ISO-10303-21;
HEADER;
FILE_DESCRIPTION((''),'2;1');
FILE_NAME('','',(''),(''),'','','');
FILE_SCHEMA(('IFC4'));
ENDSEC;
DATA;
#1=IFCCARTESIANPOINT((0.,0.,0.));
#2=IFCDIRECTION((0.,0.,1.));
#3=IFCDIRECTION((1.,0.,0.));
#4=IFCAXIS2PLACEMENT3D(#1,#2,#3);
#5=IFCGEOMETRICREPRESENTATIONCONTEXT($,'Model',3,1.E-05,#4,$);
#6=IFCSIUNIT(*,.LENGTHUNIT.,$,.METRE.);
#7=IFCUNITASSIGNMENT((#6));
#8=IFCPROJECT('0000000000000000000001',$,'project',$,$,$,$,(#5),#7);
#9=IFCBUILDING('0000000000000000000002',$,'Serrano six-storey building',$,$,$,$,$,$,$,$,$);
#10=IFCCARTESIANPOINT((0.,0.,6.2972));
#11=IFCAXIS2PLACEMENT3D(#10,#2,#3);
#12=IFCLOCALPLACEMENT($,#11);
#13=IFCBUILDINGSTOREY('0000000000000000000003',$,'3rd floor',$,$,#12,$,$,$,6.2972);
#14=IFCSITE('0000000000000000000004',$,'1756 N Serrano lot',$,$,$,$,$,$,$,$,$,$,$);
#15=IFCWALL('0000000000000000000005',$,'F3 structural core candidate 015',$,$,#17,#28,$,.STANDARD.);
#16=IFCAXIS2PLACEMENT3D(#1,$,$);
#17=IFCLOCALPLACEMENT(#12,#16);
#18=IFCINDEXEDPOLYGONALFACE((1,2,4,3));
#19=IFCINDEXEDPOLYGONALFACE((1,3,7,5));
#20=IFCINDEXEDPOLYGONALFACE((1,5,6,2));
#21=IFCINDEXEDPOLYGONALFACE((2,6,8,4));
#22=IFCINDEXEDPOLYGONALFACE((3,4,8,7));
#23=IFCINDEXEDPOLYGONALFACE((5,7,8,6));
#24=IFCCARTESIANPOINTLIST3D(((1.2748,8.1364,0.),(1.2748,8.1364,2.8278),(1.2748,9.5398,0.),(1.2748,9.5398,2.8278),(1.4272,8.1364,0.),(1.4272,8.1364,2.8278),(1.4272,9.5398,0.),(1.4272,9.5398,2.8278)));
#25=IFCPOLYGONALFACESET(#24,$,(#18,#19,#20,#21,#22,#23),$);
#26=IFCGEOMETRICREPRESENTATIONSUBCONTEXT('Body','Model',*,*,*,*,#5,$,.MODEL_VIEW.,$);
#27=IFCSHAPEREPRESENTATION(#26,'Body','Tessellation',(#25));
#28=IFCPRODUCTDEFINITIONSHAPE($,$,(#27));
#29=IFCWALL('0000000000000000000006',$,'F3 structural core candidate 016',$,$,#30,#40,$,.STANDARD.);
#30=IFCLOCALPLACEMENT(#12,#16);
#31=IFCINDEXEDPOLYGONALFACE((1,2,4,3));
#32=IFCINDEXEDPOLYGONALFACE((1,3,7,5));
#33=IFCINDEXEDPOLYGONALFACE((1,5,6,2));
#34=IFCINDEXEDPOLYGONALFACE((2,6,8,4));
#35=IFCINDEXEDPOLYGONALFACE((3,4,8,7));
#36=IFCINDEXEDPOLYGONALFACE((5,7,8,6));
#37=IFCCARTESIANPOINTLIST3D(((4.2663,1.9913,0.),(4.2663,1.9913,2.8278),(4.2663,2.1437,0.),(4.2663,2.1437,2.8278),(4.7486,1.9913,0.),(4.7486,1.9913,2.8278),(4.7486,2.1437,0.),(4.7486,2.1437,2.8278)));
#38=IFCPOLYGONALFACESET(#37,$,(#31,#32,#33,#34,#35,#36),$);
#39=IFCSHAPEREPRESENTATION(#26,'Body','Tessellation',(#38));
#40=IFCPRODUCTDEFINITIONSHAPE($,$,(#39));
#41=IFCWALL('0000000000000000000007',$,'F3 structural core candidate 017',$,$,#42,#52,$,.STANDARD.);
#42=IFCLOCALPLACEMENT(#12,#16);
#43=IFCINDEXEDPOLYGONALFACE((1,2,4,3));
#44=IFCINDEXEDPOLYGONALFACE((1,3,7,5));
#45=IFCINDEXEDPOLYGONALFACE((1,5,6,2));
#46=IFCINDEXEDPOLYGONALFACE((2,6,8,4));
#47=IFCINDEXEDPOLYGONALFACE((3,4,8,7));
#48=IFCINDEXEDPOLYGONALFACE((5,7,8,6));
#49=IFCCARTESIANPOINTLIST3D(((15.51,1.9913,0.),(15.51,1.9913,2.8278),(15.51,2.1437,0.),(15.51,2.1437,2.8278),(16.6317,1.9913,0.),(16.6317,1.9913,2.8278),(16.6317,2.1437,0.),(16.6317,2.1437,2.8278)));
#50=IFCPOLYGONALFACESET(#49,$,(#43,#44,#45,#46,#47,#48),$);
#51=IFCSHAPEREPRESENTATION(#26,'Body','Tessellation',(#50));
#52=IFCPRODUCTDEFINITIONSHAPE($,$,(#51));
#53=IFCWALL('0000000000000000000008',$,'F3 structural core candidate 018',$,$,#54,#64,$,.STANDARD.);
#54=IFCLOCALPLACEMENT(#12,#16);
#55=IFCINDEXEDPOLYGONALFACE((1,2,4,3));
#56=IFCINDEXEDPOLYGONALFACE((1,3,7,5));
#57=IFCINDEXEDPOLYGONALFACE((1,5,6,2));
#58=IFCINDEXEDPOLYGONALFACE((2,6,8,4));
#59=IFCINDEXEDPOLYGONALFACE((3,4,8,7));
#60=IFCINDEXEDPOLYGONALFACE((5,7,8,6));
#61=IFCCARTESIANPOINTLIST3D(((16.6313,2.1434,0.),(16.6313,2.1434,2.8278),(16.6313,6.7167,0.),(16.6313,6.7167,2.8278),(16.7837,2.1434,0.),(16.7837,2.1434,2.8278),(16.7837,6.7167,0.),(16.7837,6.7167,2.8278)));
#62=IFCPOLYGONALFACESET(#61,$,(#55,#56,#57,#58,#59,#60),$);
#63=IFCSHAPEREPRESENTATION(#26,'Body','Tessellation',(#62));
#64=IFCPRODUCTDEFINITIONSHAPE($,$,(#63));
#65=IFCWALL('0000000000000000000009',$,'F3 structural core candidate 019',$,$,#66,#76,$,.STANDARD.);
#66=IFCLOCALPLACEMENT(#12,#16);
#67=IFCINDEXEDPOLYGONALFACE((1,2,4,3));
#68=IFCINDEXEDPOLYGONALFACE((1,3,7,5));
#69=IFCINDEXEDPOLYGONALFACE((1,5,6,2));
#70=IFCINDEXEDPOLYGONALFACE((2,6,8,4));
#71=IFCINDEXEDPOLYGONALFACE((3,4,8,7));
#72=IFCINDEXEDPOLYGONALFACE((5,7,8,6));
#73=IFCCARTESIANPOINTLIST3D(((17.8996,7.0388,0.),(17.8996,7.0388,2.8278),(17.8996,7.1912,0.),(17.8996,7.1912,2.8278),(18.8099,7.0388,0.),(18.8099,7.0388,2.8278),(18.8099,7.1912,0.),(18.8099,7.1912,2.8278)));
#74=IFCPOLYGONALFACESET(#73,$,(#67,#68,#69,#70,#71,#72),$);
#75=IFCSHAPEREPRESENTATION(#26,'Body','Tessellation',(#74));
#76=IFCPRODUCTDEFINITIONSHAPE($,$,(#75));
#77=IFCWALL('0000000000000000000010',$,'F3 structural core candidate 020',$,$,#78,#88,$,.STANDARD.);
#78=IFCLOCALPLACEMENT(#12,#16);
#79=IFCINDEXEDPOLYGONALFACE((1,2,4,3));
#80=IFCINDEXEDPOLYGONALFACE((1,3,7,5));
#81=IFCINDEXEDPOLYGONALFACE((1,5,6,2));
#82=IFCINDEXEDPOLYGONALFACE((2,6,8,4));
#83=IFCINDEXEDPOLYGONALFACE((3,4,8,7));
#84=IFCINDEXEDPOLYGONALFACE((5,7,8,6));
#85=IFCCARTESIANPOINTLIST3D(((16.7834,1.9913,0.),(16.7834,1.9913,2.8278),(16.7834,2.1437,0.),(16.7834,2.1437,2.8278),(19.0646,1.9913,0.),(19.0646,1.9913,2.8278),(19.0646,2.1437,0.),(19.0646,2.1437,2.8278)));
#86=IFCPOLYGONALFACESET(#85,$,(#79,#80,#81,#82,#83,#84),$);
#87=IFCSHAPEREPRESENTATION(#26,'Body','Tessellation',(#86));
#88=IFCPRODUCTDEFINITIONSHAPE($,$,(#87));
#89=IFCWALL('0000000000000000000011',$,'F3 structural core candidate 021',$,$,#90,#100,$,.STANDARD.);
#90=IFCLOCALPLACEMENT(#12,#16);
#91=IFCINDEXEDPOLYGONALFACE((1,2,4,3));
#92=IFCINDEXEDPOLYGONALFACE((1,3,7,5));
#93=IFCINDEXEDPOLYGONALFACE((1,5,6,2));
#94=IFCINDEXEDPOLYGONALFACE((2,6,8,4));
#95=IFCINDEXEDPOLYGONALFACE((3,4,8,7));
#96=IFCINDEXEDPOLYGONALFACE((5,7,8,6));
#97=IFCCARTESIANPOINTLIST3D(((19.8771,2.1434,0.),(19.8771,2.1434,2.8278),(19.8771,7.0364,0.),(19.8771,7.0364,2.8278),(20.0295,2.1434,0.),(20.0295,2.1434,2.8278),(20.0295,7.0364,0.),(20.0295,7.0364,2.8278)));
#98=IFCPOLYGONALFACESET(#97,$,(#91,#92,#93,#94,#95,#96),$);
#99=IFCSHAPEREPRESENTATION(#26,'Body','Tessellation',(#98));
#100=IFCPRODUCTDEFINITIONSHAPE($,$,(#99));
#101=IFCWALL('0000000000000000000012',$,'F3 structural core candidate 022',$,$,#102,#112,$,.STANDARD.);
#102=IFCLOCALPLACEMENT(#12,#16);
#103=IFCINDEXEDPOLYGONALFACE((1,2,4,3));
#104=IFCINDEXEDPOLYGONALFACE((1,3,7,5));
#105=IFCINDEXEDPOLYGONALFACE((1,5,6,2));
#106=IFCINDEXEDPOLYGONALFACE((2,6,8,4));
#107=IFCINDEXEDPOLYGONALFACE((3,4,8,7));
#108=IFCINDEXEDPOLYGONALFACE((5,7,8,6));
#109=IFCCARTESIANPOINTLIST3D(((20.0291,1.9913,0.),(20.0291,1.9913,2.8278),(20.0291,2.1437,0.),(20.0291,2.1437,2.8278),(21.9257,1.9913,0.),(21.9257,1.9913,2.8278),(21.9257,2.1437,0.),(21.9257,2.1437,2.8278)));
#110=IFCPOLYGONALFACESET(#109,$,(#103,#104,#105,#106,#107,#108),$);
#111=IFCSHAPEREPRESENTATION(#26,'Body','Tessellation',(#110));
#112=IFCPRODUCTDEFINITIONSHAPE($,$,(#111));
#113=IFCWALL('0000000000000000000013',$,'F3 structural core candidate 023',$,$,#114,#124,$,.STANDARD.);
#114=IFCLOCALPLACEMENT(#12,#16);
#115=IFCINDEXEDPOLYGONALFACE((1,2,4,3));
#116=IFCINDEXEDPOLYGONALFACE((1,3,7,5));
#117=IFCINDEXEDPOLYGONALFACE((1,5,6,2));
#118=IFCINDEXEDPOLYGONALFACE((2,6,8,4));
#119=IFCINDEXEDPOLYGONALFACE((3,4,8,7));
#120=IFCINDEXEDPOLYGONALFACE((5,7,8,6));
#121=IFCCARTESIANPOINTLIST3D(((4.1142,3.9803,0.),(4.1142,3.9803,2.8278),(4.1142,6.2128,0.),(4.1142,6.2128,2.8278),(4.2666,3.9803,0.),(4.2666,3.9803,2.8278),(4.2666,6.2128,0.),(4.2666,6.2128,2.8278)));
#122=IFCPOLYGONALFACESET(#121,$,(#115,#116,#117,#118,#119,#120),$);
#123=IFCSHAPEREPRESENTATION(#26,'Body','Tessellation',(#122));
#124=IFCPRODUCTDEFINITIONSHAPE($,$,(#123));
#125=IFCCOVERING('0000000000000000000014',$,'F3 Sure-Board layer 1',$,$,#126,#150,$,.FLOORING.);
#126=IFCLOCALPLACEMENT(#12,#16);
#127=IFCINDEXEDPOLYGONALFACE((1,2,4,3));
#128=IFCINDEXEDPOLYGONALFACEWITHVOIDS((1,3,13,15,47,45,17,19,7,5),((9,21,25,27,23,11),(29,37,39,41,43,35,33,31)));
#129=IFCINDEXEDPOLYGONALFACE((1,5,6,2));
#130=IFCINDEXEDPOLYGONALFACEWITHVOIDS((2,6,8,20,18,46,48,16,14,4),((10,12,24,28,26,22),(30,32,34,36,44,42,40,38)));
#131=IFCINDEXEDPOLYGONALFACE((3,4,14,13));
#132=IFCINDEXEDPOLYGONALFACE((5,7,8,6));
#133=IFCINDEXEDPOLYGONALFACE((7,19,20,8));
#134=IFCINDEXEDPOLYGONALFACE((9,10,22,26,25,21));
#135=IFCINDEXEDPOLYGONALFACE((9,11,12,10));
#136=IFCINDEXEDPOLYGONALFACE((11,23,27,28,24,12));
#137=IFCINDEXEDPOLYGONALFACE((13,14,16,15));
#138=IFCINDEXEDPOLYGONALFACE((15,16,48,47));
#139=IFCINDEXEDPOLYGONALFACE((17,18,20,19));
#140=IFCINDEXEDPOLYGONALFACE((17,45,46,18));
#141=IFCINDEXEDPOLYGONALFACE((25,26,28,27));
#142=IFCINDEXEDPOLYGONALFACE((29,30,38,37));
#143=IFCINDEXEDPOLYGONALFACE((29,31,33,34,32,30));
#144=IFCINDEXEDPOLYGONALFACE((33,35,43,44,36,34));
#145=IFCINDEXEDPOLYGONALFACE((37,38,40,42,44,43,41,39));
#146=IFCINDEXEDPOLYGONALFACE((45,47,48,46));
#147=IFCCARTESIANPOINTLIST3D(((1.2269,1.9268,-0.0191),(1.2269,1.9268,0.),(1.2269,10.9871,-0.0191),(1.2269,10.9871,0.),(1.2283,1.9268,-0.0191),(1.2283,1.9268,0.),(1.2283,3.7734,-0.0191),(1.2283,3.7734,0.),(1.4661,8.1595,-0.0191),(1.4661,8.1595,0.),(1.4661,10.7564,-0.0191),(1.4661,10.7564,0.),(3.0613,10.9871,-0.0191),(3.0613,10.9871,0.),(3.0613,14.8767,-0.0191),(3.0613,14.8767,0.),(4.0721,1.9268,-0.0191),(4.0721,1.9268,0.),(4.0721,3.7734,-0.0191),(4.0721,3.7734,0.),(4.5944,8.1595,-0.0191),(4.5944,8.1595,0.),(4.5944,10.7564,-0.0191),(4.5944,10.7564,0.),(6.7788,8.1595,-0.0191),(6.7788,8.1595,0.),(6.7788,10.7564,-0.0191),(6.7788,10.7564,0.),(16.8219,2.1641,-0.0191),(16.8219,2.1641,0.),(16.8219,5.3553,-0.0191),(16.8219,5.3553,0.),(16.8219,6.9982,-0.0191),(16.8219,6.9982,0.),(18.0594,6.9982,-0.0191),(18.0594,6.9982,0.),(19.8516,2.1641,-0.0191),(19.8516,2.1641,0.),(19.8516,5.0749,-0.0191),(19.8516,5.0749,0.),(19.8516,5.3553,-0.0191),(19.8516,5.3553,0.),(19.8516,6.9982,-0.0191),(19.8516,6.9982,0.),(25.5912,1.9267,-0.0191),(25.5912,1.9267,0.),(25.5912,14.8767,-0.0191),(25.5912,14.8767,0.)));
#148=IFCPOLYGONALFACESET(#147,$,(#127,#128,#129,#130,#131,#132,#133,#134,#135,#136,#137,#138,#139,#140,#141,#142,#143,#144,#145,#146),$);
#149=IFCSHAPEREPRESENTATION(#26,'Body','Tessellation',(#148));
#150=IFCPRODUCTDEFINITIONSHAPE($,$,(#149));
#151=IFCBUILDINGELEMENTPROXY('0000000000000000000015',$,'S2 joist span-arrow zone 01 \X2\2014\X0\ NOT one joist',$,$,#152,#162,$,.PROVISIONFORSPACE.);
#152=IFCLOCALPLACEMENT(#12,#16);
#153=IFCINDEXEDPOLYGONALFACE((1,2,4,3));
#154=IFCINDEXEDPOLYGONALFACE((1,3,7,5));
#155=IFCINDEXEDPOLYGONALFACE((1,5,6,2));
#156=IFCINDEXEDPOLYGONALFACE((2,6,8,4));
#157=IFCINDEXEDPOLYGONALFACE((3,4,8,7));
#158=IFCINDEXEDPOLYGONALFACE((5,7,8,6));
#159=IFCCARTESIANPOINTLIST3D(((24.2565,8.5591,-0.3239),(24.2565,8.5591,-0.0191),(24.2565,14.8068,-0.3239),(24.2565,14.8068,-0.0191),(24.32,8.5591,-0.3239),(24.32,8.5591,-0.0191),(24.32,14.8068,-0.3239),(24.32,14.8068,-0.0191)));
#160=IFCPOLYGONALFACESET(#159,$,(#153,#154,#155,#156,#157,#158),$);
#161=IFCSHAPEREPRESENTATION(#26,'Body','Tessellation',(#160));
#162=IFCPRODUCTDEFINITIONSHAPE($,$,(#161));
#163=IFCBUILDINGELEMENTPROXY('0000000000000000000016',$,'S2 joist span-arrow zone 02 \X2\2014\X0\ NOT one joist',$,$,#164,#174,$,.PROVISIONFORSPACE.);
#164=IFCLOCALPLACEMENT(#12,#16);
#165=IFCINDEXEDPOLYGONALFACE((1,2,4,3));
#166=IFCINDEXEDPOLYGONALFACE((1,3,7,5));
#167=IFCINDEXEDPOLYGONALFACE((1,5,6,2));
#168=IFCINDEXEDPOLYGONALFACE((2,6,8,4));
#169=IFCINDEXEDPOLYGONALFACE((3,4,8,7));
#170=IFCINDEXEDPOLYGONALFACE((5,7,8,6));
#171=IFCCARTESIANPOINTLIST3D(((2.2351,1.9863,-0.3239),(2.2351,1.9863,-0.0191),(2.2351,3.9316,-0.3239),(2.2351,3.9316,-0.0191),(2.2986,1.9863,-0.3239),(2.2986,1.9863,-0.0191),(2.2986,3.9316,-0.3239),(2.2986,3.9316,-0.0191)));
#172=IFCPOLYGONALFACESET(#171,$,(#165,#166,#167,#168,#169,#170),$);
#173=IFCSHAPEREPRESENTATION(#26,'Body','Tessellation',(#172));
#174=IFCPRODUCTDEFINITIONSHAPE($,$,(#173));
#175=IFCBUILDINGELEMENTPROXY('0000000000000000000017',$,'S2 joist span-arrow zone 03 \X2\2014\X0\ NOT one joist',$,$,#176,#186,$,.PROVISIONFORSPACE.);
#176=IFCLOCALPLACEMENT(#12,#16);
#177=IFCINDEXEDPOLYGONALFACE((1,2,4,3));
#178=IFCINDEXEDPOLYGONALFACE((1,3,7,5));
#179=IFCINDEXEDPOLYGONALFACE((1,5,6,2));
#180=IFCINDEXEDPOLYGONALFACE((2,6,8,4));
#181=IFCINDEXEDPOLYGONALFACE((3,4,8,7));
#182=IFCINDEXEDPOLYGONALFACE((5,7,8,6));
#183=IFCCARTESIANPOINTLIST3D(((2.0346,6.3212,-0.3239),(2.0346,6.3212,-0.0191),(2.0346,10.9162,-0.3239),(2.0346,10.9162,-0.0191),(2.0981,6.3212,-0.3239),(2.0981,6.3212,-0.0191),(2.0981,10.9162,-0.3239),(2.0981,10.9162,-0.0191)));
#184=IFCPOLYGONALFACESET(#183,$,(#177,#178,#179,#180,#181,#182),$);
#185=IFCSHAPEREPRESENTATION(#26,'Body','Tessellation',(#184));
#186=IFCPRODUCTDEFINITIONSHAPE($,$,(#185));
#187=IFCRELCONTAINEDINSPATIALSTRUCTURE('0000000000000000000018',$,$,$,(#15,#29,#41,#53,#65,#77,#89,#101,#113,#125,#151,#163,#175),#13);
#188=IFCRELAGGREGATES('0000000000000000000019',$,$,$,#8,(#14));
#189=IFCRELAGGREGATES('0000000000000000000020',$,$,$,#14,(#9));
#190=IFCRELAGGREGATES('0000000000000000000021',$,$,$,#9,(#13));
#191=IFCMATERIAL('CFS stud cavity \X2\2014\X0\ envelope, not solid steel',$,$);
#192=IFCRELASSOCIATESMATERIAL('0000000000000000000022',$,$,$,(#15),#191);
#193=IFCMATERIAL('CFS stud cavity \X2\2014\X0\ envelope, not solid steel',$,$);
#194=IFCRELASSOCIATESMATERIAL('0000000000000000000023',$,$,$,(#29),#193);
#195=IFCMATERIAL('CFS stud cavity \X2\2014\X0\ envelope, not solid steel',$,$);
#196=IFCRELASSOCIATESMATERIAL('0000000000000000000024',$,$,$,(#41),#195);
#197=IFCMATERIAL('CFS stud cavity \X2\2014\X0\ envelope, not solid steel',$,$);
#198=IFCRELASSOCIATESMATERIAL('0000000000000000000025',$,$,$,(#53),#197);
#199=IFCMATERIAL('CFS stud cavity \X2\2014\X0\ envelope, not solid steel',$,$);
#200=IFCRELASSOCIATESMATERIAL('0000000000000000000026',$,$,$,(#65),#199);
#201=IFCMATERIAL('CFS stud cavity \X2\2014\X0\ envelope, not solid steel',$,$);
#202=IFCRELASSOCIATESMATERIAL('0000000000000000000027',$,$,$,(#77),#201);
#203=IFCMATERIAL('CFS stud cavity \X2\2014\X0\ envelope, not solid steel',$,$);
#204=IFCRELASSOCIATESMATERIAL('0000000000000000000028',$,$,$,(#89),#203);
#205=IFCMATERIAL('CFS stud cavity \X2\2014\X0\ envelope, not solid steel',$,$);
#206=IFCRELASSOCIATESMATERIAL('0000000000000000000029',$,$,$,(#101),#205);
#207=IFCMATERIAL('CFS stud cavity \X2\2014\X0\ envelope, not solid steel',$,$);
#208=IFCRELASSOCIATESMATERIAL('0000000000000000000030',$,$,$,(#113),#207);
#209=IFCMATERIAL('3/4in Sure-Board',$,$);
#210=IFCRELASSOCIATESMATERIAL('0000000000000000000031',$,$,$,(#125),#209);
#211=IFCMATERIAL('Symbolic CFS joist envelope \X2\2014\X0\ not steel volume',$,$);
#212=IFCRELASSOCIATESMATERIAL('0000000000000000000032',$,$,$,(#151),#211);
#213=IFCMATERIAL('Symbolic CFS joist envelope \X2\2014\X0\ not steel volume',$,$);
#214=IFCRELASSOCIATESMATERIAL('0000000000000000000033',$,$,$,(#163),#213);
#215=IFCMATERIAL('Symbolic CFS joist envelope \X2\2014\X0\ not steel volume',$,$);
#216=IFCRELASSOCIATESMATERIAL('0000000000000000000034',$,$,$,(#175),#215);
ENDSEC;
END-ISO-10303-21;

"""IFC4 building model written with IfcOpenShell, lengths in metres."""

from ifc_helpers import new_model, si_unit, frame, origin_with_axes, place, context, subcontext, project, spatial, polyline, outline, extrude, material, element, save


model = new_model("IFC4")

# Units and contexts
model_context = context("Model", 3, precision=1e-05, world=origin_with_axes())
body_context = subcontext(model_context, "Body", "Model", "MODEL_VIEW")
ifc_project = project(units=[si_unit("LENGTHUNIT", "METRE")], contexts=[model_context])

# Site, building, storey
site = spatial("IfcSite", under=ifc_project, Name="1756 N Serrano lot")
building = spatial("IfcBuilding", under=site, Name="Serrano six-storey building")
storey_placement = place(None, frame((0.0, 0.0, 6.2972), z_axis=(0.0, 0.0, 1.0), x_axis=(1.0, 0.0, 0.0)))
storey = spatial("IfcBuildingStorey", under=building, at=storey_placement, Name="3rd floor", Elevation=6.2972)

# Walls
ifc_material_1 = material(Name="CFS stud cavity — envelope, not solid steel")
wall_1_placement = place(storey_placement, frame((0.0, 0.0, -6.2972), z_axis=(0.0, 0.0, 1.0), x_axis=(1.0, 0.0, 0.0)))
element("IfcWall", 1, at=wall_1_placement, inside=storey, material=ifc_material_1, Name="F3 structural core candidate 015", PredefinedType="STANDARD", context=body_context, shape_type="SweptSolid", body=[
    extrude(outline(polyline([(1.4272, 8.1364), (1.2748, 8.1364), (1.2748, 9.5398), (1.4272, 9.5398), (1.4272, 8.1364)])), frame((0.0, 0.0, 6.2972)), (0.0, 0.0, 1.0), 2.8278),
])
ifc_material_2 = material(Name="CFS stud cavity — envelope, not solid steel")
wall_2_placement = place(storey_placement, frame((0.0, 0.0, -6.2972), z_axis=(0.0, 0.0, 1.0), x_axis=(1.0, 0.0, 0.0)))
element("IfcWall", 2, at=wall_2_placement, inside=storey, material=ifc_material_2, Name="F3 structural core candidate 016", PredefinedType="STANDARD", context=body_context, shape_type="SweptSolid", body=[
    extrude(outline(polyline([(4.7486, 2.1437), (4.7486, 1.9913), (4.2663, 1.9913), (4.2663, 2.1437), (4.7486, 2.1437)])), frame((0.0, 0.0, 6.2972)), (0.0, 0.0, 1.0), 2.8278),
])
ifc_material_3 = material(Name="CFS stud cavity — envelope, not solid steel")
wall_3_placement = place(storey_placement, frame((0.0, 0.0, -6.2972), z_axis=(0.0, 0.0, 1.0), x_axis=(1.0, 0.0, 0.0)))
element("IfcWall", 3, at=wall_3_placement, inside=storey, material=ifc_material_3, Name="F3 structural core candidate 017", PredefinedType="STANDARD", context=body_context, shape_type="SweptSolid", body=[
    extrude(outline(polyline([(16.6317, 2.1437), (16.6317, 1.9913), (15.51, 1.9913), (15.51, 2.1437), (16.6317, 2.1437)])), frame((0.0, 0.0, 6.2972)), (0.0, 0.0, 1.0), 2.8278),
])
ifc_material_4 = material(Name="CFS stud cavity — envelope, not solid steel")
wall_4_placement = place(storey_placement, frame((0.0, 0.0, -6.2972), z_axis=(0.0, 0.0, 1.0), x_axis=(1.0, 0.0, 0.0)))
element("IfcWall", 4, at=wall_4_placement, inside=storey, material=ifc_material_4, Name="F3 structural core candidate 018", PredefinedType="STANDARD", context=body_context, shape_type="SweptSolid", body=[
    extrude(outline(polyline([(16.7837, 2.1434), (16.6313, 2.1434), (16.6313, 6.7167), (16.7837, 6.7167), (16.7837, 2.1434)])), frame((0.0, 0.0, 6.2972)), (0.0, 0.0, 1.0), 2.8278),
])
ifc_material_5 = material(Name="CFS stud cavity — envelope, not solid steel")
wall_5_placement = place(storey_placement, frame((0.0, 0.0, -6.2972), z_axis=(0.0, 0.0, 1.0), x_axis=(1.0, 0.0, 0.0)))
element("IfcWall", 5, at=wall_5_placement, inside=storey, material=ifc_material_5, Name="F3 structural core candidate 019", PredefinedType="STANDARD", context=body_context, shape_type="SweptSolid", body=[
    extrude(outline(polyline([(18.8099, 7.1912), (18.8099, 7.0388), (17.8996, 7.0388), (17.8996, 7.1912), (18.8099, 7.1912)])), frame((0.0, 0.0, 6.2972)), (0.0, 0.0, 1.0), 2.8278),
])
ifc_material_6 = material(Name="CFS stud cavity — envelope, not solid steel")
wall_6_placement = place(storey_placement, frame((0.0, 0.0, -6.2972), z_axis=(0.0, 0.0, 1.0), x_axis=(1.0, 0.0, 0.0)))
element("IfcWall", 6, at=wall_6_placement, inside=storey, material=ifc_material_6, Name="F3 structural core candidate 020", PredefinedType="STANDARD", context=body_context, shape_type="SweptSolid", body=[
    extrude(outline(polyline([(19.0646, 2.1437), (19.0646, 1.9913), (16.7834, 1.9913), (16.7834, 2.1437), (19.0646, 2.1437)])), frame((0.0, 0.0, 6.2972)), (0.0, 0.0, 1.0), 2.8278),
])
ifc_material_7 = material(Name="CFS stud cavity — envelope, not solid steel")
wall_7_placement = place(storey_placement, frame((0.0, 0.0, -6.2972), z_axis=(0.0, 0.0, 1.0), x_axis=(1.0, 0.0, 0.0)))
element("IfcWall", 7, at=wall_7_placement, inside=storey, material=ifc_material_7, Name="F3 structural core candidate 021", PredefinedType="STANDARD", context=body_context, shape_type="SweptSolid", body=[
    extrude(outline(polyline([(20.0295, 2.1434), (19.8771, 2.1434), (19.8771, 7.0364), (20.0295, 7.0364), (20.0295, 2.1434)])), frame((0.0, 0.0, 6.2972)), (0.0, 0.0, 1.0), 2.8278),
])
ifc_material_8 = material(Name="CFS stud cavity — envelope, not solid steel")
wall_8_placement = place(storey_placement, frame((0.0, 0.0, -6.2972), z_axis=(0.0, 0.0, 1.0), x_axis=(1.0, 0.0, 0.0)))
element("IfcWall", 8, at=wall_8_placement, inside=storey, material=ifc_material_8, Name="F3 structural core candidate 022", PredefinedType="STANDARD", context=body_context, shape_type="SweptSolid", body=[
    extrude(outline(polyline([(21.9257, 2.1437), (21.9257, 1.9913), (20.0291, 1.9913), (20.0291, 2.1437), (21.9257, 2.1437)])), frame((0.0, 0.0, 6.2972)), (0.0, 0.0, 1.0), 2.8278),
])
ifc_material_9 = material(Name="CFS stud cavity — envelope, not solid steel")
wall_9_placement = place(storey_placement, frame((0.0, 0.0, -6.2972), z_axis=(0.0, 0.0, 1.0), x_axis=(1.0, 0.0, 0.0)))
element("IfcWall", 9, at=wall_9_placement, inside=storey, material=ifc_material_9, Name="F3 structural core candidate 023", PredefinedType="STANDARD", context=body_context, shape_type="SweptSolid", body=[
    extrude(outline(polyline([(4.2666, 3.9803), (4.1142, 3.9803), (4.1142, 6.2128), (4.2666, 6.2128), (4.2666, 3.9803)])), frame((0.0, 0.0, 6.2972)), (0.0, 0.0, 1.0), 2.8278),
])

# Covering
ifc_material_10 = material(Name="3/4in Sure-Board")
covering_placement = place(storey_placement, frame((0.0, 0.0, -6.2972), z_axis=(0.0, 0.0, 1.0), x_axis=(1.0, 0.0, 0.0)))
element("IfcCovering", 10, at=covering_placement, inside=storey, material=ifc_material_10, Name="F3 Sure-Board layer 1", PredefinedType="FLOORING", context=body_context, shape_type="SweptSolid", body=[
    extrude(outline(polyline([(3.0613, 14.8767), (25.5912, 14.8767), (25.5912, 1.9267), (4.0721, 1.9268), (4.0721, 3.7734), (1.2283, 3.7734), (1.2283, 1.9268), (1.2269, 1.9268), (1.2269, 10.9871), (3.0613, 10.9871), (3.0613, 14.8767)]), holes=[polyline([(6.7788, 10.7564), (4.5944, 10.7564), (1.4661, 10.7564), (1.4661, 8.1595), (4.5944, 8.1595), (6.7788, 8.1595), (6.7788, 10.7564)]), polyline([(16.8219, 5.3553), (16.8219, 2.1641), (19.8516, 2.1641), (19.8516, 5.0749), (19.8516, 5.3553), (19.8516, 6.9982), (18.0594, 6.9982), (16.8219, 6.9982), (16.8219, 5.3553)])]), frame((0.0, 0.0, 6.2781)), (0.0, 0.0, 1.0), 0.0191),
])

# Building element proxies
ifc_material_11 = material(Name="Symbolic CFS joist envelope — not steel volume")
proxy_1_placement = place(storey_placement, frame((0.0, 0.0, -6.2972), z_axis=(0.0, 0.0, 1.0), x_axis=(1.0, 0.0, 0.0)))
element("IfcBuildingElementProxy", 11, at=proxy_1_placement, inside=storey, material=ifc_material_11, Name="S2 joist span-arrow zone 01 — NOT one joist", PredefinedType="PROVISIONFORSPACE", context=body_context, shape_type="SweptSolid", body=[
    extrude(outline(polyline([(24.2565, 14.8068), (24.32, 14.8068), (24.32, 8.5591), (24.2565, 8.5591), (24.2565, 14.8068)])), frame((0.0, 0.0, 5.9733)), (0.0, 0.0, 1.0), 0.3048),
])
ifc_material_12 = material(Name="Symbolic CFS joist envelope — not steel volume")
proxy_2_placement = place(storey_placement, frame((0.0, 0.0, -6.2972), z_axis=(0.0, 0.0, 1.0), x_axis=(1.0, 0.0, 0.0)))
element("IfcBuildingElementProxy", 12, at=proxy_2_placement, inside=storey, material=ifc_material_12, Name="S2 joist span-arrow zone 02 — NOT one joist", PredefinedType="PROVISIONFORSPACE", context=body_context, shape_type="SweptSolid", body=[
    extrude(outline(polyline([(2.2351, 3.9316), (2.2986, 3.9316), (2.2986, 1.9863), (2.2351, 1.9863), (2.2351, 3.9316)])), frame((0.0, 0.0, 5.9733)), (0.0, 0.0, 1.0), 0.3048),
])
ifc_material_13 = material(Name="Symbolic CFS joist envelope — not steel volume")
proxy_3_placement = place(storey_placement, frame((0.0, 0.0, -6.2972), z_axis=(0.0, 0.0, 1.0), x_axis=(1.0, 0.0, 0.0)))
element("IfcBuildingElementProxy", 13, at=proxy_3_placement, inside=storey, material=ifc_material_13, Name="S2 joist span-arrow zone 03 — NOT one joist", PredefinedType="PROVISIONFORSPACE", context=body_context, shape_type="SweptSolid", body=[
    extrude(outline(polyline([(2.0346, 10.9162), (2.0981, 10.9162), (2.0981, 6.3212), (2.0346, 6.3212), (2.0346, 10.9162)])), frame((0.0, 0.0, 5.9733)), (0.0, 0.0, 1.0), 0.3048),
])

save(model, "model.ifc")
